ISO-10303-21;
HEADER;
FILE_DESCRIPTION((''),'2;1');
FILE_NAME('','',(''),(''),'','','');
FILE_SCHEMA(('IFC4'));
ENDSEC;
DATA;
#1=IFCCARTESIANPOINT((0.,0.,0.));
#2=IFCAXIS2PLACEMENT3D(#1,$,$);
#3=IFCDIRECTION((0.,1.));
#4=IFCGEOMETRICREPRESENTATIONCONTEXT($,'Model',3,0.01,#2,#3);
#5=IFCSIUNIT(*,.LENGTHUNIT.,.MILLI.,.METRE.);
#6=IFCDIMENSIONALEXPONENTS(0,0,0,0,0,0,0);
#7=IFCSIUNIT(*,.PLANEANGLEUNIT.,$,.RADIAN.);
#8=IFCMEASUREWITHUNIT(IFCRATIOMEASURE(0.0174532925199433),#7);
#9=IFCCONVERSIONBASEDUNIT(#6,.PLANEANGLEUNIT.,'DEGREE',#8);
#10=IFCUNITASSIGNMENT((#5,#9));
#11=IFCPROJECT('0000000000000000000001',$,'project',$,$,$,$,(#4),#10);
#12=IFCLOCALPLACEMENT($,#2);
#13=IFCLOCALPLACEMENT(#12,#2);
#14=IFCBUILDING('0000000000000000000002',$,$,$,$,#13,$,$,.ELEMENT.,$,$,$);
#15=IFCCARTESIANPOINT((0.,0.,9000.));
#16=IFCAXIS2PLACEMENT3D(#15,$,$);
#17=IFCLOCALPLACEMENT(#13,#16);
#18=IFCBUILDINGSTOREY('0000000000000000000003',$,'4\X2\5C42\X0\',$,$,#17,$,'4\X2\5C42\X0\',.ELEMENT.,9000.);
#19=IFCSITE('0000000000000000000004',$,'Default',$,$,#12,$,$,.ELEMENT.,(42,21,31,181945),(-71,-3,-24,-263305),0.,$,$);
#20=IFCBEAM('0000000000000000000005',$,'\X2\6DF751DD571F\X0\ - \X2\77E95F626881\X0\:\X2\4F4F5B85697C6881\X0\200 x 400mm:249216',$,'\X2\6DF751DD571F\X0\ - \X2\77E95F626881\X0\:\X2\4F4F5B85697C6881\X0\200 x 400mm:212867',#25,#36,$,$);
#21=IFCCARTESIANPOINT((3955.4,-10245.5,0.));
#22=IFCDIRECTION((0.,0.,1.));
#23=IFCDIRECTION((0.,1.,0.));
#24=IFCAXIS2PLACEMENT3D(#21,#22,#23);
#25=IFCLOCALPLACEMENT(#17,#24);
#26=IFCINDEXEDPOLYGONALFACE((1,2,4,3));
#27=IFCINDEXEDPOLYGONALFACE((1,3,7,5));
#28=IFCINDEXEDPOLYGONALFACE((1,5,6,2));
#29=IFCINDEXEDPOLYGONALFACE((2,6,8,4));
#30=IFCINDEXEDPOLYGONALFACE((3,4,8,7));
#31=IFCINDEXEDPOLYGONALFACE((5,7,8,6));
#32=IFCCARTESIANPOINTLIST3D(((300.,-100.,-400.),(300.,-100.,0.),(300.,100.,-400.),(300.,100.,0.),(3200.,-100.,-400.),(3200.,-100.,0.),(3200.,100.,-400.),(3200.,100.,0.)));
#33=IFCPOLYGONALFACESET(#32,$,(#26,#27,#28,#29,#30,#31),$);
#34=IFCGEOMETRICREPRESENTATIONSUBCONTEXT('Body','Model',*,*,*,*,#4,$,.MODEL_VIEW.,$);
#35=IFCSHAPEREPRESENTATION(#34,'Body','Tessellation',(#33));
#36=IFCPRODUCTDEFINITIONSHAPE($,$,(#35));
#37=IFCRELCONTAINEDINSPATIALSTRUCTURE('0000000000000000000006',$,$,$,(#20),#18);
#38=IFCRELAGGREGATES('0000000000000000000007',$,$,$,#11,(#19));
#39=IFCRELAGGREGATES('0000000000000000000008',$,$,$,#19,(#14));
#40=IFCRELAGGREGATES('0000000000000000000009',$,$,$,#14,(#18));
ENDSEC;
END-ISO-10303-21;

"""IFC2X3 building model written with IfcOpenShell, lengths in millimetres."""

from ifc_helpers import new_model, entity, si_unit, converted_unit, direction, frame, frame_2d, origin, place, context, subcontext, project, spatial, rectangle, extrude, element, save


model = new_model("IFC2X3")

# Units and contexts
model_context = context("Model", 3, precision=0.01, world=origin(), true_north=direction((0.0, 1.0)))
body_context = subcontext(model_context, "Body", "Model", "MODEL_VIEW")
ifc_project = project(units=[si_unit("LENGTHUNIT", "METRE", prefix="MILLI"), converted_unit("PLANEANGLEUNIT", "DEGREE", entity("IfcRatioMeasure", 0.0174532925199433), si_unit("PLANEANGLEUNIT", "RADIAN"), dimensions=[0, 0, 0, 0, 0, 0, 0])], contexts=[model_context])

# Site, building, storey
site_placement = place(None, origin())
site = spatial("IfcSite", under=ifc_project, at=site_placement, Name="Default", CompositionType="ELEMENT", RefLatitude=(42, 21, 31, 181945), RefLongitude=(-71, -3, -24, -263305), RefElevation=0.0)
building_placement = place(site_placement, origin())
building = spatial("IfcBuilding", under=site, at=building_placement, CompositionType="ELEMENT")
storey_placement = place(building_placement, frame((0.0, 0.0, 9000.0)))
storey = spatial("IfcBuildingStorey", under=building, at=storey_placement, Name="4层", LongName="4层", CompositionType="ELEMENT", Elevation=9000.0)

# Beam
beam_1_placement = place(storey_placement, frame((3955.4, -10245.5, 0.0), z_axis=(0.0, 0.0, 1.0), x_axis=(0.0, 1.0, 0.0)))
element("IfcBeam", 1, at=beam_1_placement, inside=storey, Name="混凝土 - 矩形梁:住宅楼梁200 x 400mm:249216", ObjectType="混凝土 - 矩形梁:住宅楼梁200 x 400mm:212867", context=body_context, shape_type="SweptSolid", body=[
    extrude(rectangle(XDim=400.0, YDim=200.0, at=frame_2d((0.0, 0.0), x_axis=(1.0, 0.0))), frame((300.0, 0.0, -200.0), z_axis=(1.0, 0.0, 0.0), x_axis=(0.0, 0.0, -1.0)), (0.0, 0.0, 1.0), 2900.0),
])

save(model, "model.ifc")
